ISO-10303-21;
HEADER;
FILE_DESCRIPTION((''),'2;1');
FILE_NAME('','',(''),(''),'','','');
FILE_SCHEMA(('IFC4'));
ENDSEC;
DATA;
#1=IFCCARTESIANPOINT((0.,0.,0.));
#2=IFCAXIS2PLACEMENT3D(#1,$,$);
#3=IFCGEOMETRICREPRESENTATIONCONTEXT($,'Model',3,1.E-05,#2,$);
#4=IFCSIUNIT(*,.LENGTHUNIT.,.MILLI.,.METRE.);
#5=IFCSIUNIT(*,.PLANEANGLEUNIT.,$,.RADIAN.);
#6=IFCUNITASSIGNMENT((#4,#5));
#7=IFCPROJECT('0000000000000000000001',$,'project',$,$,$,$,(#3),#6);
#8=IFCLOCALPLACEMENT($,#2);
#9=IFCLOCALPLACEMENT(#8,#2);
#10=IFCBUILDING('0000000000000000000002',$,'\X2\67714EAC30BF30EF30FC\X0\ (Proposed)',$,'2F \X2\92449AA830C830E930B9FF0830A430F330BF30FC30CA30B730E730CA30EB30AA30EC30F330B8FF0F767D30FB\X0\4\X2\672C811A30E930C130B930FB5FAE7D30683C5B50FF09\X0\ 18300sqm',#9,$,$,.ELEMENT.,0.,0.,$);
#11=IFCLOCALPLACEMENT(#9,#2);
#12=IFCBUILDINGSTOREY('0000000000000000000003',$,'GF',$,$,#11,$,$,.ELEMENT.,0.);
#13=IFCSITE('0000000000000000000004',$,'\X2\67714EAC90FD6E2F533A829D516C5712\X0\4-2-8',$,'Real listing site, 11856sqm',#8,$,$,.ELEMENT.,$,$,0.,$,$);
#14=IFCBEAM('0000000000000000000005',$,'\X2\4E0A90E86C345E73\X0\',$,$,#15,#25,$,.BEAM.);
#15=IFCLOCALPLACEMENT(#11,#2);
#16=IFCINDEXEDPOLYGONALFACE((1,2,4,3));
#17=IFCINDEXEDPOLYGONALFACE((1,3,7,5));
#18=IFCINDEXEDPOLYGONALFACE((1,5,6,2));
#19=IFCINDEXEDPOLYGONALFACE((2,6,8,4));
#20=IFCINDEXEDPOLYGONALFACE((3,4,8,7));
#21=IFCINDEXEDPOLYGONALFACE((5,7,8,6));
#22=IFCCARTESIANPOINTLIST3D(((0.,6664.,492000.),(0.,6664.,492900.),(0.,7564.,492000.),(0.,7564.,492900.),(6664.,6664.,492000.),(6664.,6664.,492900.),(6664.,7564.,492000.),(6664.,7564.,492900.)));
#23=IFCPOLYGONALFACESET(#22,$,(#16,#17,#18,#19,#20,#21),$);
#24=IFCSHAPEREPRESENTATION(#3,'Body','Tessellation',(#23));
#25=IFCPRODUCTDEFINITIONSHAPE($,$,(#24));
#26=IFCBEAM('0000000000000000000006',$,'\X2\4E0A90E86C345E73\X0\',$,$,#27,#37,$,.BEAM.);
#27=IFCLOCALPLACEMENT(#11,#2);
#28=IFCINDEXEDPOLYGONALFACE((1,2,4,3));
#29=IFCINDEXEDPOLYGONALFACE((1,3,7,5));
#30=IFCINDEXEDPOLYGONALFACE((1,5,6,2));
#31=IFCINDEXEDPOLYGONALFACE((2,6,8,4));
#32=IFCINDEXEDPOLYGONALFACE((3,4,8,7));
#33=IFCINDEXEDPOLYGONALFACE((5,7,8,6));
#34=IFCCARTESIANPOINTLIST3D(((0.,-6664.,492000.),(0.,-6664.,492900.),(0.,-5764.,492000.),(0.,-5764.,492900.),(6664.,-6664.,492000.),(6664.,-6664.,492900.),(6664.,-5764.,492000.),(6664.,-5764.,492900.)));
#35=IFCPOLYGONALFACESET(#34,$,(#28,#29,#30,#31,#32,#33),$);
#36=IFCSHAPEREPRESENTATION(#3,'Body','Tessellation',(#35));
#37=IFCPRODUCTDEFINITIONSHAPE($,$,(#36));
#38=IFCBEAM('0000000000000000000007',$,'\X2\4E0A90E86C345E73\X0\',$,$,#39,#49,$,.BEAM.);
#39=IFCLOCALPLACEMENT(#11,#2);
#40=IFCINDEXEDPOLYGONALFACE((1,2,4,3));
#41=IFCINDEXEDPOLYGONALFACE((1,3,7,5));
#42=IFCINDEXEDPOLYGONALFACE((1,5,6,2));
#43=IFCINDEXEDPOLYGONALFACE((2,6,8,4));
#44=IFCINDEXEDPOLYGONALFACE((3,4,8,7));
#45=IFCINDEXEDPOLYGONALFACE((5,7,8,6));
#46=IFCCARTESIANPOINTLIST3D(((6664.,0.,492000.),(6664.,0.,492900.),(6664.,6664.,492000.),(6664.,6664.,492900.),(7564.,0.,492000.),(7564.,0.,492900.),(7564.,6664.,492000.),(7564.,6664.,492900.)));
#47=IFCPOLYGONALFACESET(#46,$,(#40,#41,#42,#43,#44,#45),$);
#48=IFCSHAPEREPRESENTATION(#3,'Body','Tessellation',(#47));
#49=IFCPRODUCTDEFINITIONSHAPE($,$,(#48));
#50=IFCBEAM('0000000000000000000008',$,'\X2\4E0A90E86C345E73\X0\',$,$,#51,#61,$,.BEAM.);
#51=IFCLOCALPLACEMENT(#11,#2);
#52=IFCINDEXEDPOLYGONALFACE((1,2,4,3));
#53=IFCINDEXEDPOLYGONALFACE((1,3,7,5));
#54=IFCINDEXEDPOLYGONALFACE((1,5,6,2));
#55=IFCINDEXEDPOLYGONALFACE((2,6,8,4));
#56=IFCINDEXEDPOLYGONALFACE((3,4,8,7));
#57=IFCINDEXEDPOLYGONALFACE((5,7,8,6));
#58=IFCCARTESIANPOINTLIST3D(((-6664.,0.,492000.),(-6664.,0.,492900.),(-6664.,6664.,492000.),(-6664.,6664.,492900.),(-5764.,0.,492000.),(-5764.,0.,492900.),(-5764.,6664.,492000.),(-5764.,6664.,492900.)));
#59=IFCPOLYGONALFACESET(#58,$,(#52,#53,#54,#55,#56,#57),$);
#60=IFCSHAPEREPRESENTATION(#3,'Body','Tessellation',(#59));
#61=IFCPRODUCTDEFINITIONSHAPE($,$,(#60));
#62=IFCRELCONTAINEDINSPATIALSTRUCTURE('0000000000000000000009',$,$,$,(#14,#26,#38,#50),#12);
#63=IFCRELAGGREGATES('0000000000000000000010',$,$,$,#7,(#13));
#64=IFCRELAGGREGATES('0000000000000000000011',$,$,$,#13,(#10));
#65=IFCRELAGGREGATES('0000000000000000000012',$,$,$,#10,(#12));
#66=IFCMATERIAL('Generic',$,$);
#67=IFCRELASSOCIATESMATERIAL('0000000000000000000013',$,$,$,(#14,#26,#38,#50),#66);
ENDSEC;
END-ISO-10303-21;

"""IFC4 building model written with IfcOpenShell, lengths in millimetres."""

from ifc_helpers import new_model, si_unit, frame, frame_2d, origin, place, context, project, spatial, rectangle, extrude, material, element, save


model = new_model("IFC4")

# Units and contexts
model_context = context("Model", 3, precision=1e-05, world=origin())
ifc_project = project(units=[si_unit("LENGTHUNIT", "METRE", prefix="MILLI"), si_unit("PLANEANGLEUNIT", "RADIAN")], contexts=[model_context])

# Site, building, storey
site_placement = place(None, origin())
site = spatial("IfcSite", under=ifc_project, at=site_placement, Name="東京都港区芝公園4-2-8", ObjectType="Real listing site, 11856sqm", CompositionType="ELEMENT", RefElevation=0.0)
building_placement = place(site_placement, origin())
building = spatial("IfcBuilding", under=site, at=building_placement, Name="東京タワー (Proposed)", ObjectType="2F 鉄骨トラス（インターナショナルオレンジ／白・4本脚ラチス・微細格子） 18300sqm", CompositionType="ELEMENT", ElevationOfRefHeight=0.0, ElevationOfTerrain=0.0)
storey_placement = place(building_placement, origin())
storey = spatial("IfcBuildingStorey", under=building, at=storey_placement, Name="GF", CompositionType="ELEMENT", Elevation=0.0)

# Shared definitions
ifc_material = material(Name="Generic")

# Beams
beam_1_placement = place(storey_placement, frame((0.0, 3332.0, 246000.0)))
element("IfcBeam", 1, at=beam_1_placement, inside=storey, material=ifc_material, Name="上部水平", PredefinedType="BEAM", context=model_context, shape_type="SweptSolid", body=[
    extrude(rectangle(XDim=6664.0, YDim=900.0, at=frame_2d((3332.0, 450.0))), frame((0.0, 3332.0, 246000.0)), (0.0, 0.0, 1.0), 900.0),
])
beam_2_placement = place(storey_placement, frame((0.0, -3332.0, 246000.0)))
element("IfcBeam", 2, at=beam_2_placement, inside=storey, material=ifc_material, Name="上部水平", PredefinedType="BEAM", context=model_context, shape_type="SweptSolid", body=[
    extrude(rectangle(XDim=6664.0, YDim=900.0, at=frame_2d((3332.0, 450.0))), frame((0.0, -3332.0, 246000.0)), (0.0, 0.0, 1.0), 900.0),
])
beam_3_placement = place(storey_placement, frame((3332.0, 0.0, 246000.0)))
element("IfcBeam", 3, at=beam_3_placement, inside=storey, material=ifc_material, Name="上部水平", PredefinedType="BEAM", context=model_context, shape_type="SweptSolid", body=[
    extrude(rectangle(XDim=900.0, YDim=6664.0, at=frame_2d((450.0, 3332.0))), frame((3332.0, 0.0, 246000.0)), (0.0, 0.0, 1.0), 900.0),
])
beam_4_placement = place(storey_placement, frame((-3332.0, 0.0, 246000.0)))
element("IfcBeam", 4, at=beam_4_placement, inside=storey, material=ifc_material, Name="上部水平", PredefinedType="BEAM", context=model_context, shape_type="SweptSolid", body=[
    extrude(rectangle(XDim=900.0, YDim=6664.0, at=frame_2d((450.0, 3332.0))), frame((-3332.0, 0.0, 246000.0)), (0.0, 0.0, 1.0), 900.0),
])

save(model, "model.ifc")
